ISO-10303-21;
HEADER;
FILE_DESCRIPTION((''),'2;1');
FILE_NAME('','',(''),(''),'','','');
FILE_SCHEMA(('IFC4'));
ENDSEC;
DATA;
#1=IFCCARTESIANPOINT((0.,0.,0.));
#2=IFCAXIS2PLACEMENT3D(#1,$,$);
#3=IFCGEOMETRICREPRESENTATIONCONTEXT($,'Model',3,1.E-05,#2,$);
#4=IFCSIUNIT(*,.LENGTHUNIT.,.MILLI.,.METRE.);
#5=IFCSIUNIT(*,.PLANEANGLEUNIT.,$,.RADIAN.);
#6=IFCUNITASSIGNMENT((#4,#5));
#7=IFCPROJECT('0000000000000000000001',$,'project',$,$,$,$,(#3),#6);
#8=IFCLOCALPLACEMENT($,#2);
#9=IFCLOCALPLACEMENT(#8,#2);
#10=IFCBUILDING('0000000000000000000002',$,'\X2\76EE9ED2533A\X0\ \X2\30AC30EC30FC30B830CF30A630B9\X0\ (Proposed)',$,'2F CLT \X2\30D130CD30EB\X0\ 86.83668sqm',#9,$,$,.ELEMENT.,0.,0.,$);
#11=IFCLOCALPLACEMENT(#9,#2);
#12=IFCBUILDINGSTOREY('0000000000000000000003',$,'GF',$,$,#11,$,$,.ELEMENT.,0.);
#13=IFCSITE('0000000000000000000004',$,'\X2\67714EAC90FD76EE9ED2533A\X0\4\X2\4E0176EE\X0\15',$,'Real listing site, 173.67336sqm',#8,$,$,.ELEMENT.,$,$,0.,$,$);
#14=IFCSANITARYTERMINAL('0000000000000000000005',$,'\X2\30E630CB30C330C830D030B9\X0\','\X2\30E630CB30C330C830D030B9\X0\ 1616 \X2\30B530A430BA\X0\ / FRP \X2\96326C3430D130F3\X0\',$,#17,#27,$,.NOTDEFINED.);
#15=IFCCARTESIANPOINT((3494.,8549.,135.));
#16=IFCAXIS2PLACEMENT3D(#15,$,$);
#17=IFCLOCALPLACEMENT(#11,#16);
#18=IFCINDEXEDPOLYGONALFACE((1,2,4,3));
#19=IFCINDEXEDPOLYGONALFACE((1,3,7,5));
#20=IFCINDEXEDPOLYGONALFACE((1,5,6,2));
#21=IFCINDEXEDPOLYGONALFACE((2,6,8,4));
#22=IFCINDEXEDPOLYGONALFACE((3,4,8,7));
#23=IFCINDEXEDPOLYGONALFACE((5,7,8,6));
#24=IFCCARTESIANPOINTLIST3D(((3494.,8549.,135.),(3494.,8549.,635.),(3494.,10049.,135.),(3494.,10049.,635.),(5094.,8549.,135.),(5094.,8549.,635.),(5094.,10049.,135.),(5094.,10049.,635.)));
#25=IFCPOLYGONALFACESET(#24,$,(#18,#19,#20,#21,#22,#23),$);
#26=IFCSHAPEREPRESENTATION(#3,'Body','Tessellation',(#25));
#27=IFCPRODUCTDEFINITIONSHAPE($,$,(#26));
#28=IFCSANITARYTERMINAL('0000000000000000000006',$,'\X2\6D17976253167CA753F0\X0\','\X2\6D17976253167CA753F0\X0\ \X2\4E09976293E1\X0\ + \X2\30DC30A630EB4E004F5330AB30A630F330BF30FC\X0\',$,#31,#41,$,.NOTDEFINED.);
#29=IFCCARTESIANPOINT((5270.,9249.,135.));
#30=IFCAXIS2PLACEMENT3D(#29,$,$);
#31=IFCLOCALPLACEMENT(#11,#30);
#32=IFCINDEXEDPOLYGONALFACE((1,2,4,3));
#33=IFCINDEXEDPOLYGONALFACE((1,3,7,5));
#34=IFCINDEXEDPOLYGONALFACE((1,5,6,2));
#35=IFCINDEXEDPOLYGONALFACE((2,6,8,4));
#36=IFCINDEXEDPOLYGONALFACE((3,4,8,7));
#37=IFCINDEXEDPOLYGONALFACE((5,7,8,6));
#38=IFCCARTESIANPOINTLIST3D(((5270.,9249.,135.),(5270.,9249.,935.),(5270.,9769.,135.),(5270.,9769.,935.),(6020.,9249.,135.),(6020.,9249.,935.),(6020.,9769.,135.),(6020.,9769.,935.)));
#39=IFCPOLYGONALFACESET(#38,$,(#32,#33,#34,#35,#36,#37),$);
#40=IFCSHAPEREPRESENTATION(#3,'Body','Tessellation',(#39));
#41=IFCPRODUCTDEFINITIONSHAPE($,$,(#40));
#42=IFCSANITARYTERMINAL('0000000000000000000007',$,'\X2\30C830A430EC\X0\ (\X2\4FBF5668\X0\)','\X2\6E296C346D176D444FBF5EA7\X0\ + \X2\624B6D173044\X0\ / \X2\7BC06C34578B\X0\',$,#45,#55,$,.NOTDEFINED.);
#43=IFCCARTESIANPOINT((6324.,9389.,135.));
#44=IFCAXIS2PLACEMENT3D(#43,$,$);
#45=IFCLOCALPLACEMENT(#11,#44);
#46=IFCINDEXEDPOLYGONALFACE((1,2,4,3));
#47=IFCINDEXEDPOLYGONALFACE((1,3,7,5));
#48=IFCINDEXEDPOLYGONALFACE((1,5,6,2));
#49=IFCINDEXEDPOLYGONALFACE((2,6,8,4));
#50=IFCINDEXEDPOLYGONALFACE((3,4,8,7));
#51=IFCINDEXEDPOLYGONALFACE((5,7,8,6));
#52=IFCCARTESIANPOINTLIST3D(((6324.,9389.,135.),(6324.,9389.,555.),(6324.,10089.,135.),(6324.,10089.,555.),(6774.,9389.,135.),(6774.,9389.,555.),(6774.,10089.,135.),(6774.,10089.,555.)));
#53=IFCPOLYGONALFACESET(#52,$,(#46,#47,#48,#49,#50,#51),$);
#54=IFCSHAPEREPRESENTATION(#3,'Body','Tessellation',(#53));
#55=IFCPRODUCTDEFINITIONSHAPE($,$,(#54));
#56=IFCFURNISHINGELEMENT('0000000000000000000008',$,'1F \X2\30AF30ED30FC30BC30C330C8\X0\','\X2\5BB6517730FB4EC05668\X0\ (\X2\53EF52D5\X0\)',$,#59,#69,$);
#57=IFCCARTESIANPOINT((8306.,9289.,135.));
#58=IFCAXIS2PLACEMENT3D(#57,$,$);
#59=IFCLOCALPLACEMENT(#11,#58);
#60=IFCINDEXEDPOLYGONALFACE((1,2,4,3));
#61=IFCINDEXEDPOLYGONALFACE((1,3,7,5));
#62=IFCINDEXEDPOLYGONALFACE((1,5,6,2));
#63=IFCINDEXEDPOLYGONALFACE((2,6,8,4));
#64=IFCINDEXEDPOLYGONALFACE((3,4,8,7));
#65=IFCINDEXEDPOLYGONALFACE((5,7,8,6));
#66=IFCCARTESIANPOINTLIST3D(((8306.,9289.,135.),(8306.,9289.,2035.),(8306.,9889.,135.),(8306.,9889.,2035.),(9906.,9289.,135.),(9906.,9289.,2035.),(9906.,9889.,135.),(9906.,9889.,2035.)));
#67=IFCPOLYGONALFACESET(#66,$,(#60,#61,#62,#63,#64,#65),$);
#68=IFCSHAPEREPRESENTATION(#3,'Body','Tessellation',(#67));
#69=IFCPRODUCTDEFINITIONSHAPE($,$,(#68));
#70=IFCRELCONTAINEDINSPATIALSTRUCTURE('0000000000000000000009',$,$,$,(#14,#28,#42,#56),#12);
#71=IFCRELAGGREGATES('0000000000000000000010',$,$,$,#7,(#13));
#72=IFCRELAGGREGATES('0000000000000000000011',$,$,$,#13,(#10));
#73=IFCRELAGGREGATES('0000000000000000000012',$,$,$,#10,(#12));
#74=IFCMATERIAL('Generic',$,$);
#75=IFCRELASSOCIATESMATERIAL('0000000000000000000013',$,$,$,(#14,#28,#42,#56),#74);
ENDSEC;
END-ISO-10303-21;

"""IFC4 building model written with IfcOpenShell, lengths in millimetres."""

from ifc_helpers import new_model, si_unit, frame, frame_2d, origin, place, context, project, spatial, rectangle, extrude, material, element, save


model = new_model("IFC4")

# Units and contexts
model_context = context("Model", 3, precision=1e-05, world=origin())
ifc_project = project(units=[si_unit("LENGTHUNIT", "METRE", prefix="MILLI"), si_unit("PLANEANGLEUNIT", "RADIAN")], contexts=[model_context])

# Site, building, storey
site_placement = place(None, origin())
site = spatial("IfcSite", under=ifc_project, at=site_placement, Name="東京都目黒区4丁目15", ObjectType="Real listing site, 173.67336sqm", CompositionType="ELEMENT", RefElevation=0.0)
building_placement = place(site_placement, origin())
building = spatial("IfcBuilding", under=site, at=building_placement, Name="目黒区 ガレージハウス (Proposed)", ObjectType="2F CLT パネル 86.83668sqm", CompositionType="ELEMENT", ElevationOfRefHeight=0.0, ElevationOfTerrain=0.0)
storey_placement = place(building_placement, origin())
storey = spatial("IfcBuildingStorey", under=building, at=storey_placement, Name="GF", CompositionType="ELEMENT", Elevation=0.0)

# Shared definitions
ifc_material_1 = material(Name="Generic")

# Sanitary terminals
sanitary_terminal_1_placement = place(storey_placement, frame((3494.0, 8549.0, 135.0)))
element("IfcSanitaryTerminal", 1, at=sanitary_terminal_1_placement, inside=storey, material=ifc_material_1, Name="ユニットバス", Description="ユニットバス 1616 サイズ / FRP 防水パン", PredefinedType="NOTDEFINED", context=model_context, shape_type="SweptSolid", body=[
    extrude(rectangle(XDim=1600.0, YDim=1500.0, at=frame_2d((800.0, 750.0))), frame((3494.0, 8549.0, 135.0)), (0.0, 0.0, 1.0), 500.0),
])
sanitary_terminal_2_placement = place(storey_placement, frame((5270.0, 9249.0, 135.0)))
element("IfcSanitaryTerminal", 2, at=sanitary_terminal_2_placement, inside=storey, material=ifc_material_1, Name="洗面化粧台", Description="洗面化粧台 三面鏡 + ボウル一体カウンター", PredefinedType="NOTDEFINED", context=model_context, shape_type="SweptSolid", body=[
    extrude(rectangle(XDim=750.0, YDim=520.0, at=frame_2d((375.0, 260.0))), frame((5270.0, 9249.0, 135.0)), (0.0, 0.0, 1.0), 800.0),
])
sanitary_terminal_3_placement = place(storey_placement, frame((6324.0, 9389.0, 135.0)))
element("IfcSanitaryTerminal", 3, at=sanitary_terminal_3_placement, inside=storey, material=ifc_material_1, Name="トイレ (便器)", Description="温水洗浄便座 + 手洗い / 節水型", PredefinedType="NOTDEFINED", context=model_context, shape_type="SweptSolid", body=[
    extrude(rectangle(XDim=450.0, YDim=700.0, at=frame_2d((225.0, 350.0))), frame((6324.0, 9389.0, 135.0)), (0.0, 0.0, 1.0), 420.0),
])

# Furnishing element
furnishing_placement = place(storey_placement, frame((8306.0, 9289.0, 135.0)))
element("IfcFurnishingElement", 4, at=furnishing_placement, inside=storey, material=ifc_material_1, Name="1F クローゼット", Description="家具・什器 (可動)", context=model_context, shape_type="SweptSolid", body=[
    extrude(rectangle(XDim=1600.0, YDim=600.0, at=frame_2d((800.0, 300.0))), frame((8306.0, 9289.0, 135.0)), (0.0, 0.0, 1.0), 1900.0),
])

save(model, "model.ifc")
